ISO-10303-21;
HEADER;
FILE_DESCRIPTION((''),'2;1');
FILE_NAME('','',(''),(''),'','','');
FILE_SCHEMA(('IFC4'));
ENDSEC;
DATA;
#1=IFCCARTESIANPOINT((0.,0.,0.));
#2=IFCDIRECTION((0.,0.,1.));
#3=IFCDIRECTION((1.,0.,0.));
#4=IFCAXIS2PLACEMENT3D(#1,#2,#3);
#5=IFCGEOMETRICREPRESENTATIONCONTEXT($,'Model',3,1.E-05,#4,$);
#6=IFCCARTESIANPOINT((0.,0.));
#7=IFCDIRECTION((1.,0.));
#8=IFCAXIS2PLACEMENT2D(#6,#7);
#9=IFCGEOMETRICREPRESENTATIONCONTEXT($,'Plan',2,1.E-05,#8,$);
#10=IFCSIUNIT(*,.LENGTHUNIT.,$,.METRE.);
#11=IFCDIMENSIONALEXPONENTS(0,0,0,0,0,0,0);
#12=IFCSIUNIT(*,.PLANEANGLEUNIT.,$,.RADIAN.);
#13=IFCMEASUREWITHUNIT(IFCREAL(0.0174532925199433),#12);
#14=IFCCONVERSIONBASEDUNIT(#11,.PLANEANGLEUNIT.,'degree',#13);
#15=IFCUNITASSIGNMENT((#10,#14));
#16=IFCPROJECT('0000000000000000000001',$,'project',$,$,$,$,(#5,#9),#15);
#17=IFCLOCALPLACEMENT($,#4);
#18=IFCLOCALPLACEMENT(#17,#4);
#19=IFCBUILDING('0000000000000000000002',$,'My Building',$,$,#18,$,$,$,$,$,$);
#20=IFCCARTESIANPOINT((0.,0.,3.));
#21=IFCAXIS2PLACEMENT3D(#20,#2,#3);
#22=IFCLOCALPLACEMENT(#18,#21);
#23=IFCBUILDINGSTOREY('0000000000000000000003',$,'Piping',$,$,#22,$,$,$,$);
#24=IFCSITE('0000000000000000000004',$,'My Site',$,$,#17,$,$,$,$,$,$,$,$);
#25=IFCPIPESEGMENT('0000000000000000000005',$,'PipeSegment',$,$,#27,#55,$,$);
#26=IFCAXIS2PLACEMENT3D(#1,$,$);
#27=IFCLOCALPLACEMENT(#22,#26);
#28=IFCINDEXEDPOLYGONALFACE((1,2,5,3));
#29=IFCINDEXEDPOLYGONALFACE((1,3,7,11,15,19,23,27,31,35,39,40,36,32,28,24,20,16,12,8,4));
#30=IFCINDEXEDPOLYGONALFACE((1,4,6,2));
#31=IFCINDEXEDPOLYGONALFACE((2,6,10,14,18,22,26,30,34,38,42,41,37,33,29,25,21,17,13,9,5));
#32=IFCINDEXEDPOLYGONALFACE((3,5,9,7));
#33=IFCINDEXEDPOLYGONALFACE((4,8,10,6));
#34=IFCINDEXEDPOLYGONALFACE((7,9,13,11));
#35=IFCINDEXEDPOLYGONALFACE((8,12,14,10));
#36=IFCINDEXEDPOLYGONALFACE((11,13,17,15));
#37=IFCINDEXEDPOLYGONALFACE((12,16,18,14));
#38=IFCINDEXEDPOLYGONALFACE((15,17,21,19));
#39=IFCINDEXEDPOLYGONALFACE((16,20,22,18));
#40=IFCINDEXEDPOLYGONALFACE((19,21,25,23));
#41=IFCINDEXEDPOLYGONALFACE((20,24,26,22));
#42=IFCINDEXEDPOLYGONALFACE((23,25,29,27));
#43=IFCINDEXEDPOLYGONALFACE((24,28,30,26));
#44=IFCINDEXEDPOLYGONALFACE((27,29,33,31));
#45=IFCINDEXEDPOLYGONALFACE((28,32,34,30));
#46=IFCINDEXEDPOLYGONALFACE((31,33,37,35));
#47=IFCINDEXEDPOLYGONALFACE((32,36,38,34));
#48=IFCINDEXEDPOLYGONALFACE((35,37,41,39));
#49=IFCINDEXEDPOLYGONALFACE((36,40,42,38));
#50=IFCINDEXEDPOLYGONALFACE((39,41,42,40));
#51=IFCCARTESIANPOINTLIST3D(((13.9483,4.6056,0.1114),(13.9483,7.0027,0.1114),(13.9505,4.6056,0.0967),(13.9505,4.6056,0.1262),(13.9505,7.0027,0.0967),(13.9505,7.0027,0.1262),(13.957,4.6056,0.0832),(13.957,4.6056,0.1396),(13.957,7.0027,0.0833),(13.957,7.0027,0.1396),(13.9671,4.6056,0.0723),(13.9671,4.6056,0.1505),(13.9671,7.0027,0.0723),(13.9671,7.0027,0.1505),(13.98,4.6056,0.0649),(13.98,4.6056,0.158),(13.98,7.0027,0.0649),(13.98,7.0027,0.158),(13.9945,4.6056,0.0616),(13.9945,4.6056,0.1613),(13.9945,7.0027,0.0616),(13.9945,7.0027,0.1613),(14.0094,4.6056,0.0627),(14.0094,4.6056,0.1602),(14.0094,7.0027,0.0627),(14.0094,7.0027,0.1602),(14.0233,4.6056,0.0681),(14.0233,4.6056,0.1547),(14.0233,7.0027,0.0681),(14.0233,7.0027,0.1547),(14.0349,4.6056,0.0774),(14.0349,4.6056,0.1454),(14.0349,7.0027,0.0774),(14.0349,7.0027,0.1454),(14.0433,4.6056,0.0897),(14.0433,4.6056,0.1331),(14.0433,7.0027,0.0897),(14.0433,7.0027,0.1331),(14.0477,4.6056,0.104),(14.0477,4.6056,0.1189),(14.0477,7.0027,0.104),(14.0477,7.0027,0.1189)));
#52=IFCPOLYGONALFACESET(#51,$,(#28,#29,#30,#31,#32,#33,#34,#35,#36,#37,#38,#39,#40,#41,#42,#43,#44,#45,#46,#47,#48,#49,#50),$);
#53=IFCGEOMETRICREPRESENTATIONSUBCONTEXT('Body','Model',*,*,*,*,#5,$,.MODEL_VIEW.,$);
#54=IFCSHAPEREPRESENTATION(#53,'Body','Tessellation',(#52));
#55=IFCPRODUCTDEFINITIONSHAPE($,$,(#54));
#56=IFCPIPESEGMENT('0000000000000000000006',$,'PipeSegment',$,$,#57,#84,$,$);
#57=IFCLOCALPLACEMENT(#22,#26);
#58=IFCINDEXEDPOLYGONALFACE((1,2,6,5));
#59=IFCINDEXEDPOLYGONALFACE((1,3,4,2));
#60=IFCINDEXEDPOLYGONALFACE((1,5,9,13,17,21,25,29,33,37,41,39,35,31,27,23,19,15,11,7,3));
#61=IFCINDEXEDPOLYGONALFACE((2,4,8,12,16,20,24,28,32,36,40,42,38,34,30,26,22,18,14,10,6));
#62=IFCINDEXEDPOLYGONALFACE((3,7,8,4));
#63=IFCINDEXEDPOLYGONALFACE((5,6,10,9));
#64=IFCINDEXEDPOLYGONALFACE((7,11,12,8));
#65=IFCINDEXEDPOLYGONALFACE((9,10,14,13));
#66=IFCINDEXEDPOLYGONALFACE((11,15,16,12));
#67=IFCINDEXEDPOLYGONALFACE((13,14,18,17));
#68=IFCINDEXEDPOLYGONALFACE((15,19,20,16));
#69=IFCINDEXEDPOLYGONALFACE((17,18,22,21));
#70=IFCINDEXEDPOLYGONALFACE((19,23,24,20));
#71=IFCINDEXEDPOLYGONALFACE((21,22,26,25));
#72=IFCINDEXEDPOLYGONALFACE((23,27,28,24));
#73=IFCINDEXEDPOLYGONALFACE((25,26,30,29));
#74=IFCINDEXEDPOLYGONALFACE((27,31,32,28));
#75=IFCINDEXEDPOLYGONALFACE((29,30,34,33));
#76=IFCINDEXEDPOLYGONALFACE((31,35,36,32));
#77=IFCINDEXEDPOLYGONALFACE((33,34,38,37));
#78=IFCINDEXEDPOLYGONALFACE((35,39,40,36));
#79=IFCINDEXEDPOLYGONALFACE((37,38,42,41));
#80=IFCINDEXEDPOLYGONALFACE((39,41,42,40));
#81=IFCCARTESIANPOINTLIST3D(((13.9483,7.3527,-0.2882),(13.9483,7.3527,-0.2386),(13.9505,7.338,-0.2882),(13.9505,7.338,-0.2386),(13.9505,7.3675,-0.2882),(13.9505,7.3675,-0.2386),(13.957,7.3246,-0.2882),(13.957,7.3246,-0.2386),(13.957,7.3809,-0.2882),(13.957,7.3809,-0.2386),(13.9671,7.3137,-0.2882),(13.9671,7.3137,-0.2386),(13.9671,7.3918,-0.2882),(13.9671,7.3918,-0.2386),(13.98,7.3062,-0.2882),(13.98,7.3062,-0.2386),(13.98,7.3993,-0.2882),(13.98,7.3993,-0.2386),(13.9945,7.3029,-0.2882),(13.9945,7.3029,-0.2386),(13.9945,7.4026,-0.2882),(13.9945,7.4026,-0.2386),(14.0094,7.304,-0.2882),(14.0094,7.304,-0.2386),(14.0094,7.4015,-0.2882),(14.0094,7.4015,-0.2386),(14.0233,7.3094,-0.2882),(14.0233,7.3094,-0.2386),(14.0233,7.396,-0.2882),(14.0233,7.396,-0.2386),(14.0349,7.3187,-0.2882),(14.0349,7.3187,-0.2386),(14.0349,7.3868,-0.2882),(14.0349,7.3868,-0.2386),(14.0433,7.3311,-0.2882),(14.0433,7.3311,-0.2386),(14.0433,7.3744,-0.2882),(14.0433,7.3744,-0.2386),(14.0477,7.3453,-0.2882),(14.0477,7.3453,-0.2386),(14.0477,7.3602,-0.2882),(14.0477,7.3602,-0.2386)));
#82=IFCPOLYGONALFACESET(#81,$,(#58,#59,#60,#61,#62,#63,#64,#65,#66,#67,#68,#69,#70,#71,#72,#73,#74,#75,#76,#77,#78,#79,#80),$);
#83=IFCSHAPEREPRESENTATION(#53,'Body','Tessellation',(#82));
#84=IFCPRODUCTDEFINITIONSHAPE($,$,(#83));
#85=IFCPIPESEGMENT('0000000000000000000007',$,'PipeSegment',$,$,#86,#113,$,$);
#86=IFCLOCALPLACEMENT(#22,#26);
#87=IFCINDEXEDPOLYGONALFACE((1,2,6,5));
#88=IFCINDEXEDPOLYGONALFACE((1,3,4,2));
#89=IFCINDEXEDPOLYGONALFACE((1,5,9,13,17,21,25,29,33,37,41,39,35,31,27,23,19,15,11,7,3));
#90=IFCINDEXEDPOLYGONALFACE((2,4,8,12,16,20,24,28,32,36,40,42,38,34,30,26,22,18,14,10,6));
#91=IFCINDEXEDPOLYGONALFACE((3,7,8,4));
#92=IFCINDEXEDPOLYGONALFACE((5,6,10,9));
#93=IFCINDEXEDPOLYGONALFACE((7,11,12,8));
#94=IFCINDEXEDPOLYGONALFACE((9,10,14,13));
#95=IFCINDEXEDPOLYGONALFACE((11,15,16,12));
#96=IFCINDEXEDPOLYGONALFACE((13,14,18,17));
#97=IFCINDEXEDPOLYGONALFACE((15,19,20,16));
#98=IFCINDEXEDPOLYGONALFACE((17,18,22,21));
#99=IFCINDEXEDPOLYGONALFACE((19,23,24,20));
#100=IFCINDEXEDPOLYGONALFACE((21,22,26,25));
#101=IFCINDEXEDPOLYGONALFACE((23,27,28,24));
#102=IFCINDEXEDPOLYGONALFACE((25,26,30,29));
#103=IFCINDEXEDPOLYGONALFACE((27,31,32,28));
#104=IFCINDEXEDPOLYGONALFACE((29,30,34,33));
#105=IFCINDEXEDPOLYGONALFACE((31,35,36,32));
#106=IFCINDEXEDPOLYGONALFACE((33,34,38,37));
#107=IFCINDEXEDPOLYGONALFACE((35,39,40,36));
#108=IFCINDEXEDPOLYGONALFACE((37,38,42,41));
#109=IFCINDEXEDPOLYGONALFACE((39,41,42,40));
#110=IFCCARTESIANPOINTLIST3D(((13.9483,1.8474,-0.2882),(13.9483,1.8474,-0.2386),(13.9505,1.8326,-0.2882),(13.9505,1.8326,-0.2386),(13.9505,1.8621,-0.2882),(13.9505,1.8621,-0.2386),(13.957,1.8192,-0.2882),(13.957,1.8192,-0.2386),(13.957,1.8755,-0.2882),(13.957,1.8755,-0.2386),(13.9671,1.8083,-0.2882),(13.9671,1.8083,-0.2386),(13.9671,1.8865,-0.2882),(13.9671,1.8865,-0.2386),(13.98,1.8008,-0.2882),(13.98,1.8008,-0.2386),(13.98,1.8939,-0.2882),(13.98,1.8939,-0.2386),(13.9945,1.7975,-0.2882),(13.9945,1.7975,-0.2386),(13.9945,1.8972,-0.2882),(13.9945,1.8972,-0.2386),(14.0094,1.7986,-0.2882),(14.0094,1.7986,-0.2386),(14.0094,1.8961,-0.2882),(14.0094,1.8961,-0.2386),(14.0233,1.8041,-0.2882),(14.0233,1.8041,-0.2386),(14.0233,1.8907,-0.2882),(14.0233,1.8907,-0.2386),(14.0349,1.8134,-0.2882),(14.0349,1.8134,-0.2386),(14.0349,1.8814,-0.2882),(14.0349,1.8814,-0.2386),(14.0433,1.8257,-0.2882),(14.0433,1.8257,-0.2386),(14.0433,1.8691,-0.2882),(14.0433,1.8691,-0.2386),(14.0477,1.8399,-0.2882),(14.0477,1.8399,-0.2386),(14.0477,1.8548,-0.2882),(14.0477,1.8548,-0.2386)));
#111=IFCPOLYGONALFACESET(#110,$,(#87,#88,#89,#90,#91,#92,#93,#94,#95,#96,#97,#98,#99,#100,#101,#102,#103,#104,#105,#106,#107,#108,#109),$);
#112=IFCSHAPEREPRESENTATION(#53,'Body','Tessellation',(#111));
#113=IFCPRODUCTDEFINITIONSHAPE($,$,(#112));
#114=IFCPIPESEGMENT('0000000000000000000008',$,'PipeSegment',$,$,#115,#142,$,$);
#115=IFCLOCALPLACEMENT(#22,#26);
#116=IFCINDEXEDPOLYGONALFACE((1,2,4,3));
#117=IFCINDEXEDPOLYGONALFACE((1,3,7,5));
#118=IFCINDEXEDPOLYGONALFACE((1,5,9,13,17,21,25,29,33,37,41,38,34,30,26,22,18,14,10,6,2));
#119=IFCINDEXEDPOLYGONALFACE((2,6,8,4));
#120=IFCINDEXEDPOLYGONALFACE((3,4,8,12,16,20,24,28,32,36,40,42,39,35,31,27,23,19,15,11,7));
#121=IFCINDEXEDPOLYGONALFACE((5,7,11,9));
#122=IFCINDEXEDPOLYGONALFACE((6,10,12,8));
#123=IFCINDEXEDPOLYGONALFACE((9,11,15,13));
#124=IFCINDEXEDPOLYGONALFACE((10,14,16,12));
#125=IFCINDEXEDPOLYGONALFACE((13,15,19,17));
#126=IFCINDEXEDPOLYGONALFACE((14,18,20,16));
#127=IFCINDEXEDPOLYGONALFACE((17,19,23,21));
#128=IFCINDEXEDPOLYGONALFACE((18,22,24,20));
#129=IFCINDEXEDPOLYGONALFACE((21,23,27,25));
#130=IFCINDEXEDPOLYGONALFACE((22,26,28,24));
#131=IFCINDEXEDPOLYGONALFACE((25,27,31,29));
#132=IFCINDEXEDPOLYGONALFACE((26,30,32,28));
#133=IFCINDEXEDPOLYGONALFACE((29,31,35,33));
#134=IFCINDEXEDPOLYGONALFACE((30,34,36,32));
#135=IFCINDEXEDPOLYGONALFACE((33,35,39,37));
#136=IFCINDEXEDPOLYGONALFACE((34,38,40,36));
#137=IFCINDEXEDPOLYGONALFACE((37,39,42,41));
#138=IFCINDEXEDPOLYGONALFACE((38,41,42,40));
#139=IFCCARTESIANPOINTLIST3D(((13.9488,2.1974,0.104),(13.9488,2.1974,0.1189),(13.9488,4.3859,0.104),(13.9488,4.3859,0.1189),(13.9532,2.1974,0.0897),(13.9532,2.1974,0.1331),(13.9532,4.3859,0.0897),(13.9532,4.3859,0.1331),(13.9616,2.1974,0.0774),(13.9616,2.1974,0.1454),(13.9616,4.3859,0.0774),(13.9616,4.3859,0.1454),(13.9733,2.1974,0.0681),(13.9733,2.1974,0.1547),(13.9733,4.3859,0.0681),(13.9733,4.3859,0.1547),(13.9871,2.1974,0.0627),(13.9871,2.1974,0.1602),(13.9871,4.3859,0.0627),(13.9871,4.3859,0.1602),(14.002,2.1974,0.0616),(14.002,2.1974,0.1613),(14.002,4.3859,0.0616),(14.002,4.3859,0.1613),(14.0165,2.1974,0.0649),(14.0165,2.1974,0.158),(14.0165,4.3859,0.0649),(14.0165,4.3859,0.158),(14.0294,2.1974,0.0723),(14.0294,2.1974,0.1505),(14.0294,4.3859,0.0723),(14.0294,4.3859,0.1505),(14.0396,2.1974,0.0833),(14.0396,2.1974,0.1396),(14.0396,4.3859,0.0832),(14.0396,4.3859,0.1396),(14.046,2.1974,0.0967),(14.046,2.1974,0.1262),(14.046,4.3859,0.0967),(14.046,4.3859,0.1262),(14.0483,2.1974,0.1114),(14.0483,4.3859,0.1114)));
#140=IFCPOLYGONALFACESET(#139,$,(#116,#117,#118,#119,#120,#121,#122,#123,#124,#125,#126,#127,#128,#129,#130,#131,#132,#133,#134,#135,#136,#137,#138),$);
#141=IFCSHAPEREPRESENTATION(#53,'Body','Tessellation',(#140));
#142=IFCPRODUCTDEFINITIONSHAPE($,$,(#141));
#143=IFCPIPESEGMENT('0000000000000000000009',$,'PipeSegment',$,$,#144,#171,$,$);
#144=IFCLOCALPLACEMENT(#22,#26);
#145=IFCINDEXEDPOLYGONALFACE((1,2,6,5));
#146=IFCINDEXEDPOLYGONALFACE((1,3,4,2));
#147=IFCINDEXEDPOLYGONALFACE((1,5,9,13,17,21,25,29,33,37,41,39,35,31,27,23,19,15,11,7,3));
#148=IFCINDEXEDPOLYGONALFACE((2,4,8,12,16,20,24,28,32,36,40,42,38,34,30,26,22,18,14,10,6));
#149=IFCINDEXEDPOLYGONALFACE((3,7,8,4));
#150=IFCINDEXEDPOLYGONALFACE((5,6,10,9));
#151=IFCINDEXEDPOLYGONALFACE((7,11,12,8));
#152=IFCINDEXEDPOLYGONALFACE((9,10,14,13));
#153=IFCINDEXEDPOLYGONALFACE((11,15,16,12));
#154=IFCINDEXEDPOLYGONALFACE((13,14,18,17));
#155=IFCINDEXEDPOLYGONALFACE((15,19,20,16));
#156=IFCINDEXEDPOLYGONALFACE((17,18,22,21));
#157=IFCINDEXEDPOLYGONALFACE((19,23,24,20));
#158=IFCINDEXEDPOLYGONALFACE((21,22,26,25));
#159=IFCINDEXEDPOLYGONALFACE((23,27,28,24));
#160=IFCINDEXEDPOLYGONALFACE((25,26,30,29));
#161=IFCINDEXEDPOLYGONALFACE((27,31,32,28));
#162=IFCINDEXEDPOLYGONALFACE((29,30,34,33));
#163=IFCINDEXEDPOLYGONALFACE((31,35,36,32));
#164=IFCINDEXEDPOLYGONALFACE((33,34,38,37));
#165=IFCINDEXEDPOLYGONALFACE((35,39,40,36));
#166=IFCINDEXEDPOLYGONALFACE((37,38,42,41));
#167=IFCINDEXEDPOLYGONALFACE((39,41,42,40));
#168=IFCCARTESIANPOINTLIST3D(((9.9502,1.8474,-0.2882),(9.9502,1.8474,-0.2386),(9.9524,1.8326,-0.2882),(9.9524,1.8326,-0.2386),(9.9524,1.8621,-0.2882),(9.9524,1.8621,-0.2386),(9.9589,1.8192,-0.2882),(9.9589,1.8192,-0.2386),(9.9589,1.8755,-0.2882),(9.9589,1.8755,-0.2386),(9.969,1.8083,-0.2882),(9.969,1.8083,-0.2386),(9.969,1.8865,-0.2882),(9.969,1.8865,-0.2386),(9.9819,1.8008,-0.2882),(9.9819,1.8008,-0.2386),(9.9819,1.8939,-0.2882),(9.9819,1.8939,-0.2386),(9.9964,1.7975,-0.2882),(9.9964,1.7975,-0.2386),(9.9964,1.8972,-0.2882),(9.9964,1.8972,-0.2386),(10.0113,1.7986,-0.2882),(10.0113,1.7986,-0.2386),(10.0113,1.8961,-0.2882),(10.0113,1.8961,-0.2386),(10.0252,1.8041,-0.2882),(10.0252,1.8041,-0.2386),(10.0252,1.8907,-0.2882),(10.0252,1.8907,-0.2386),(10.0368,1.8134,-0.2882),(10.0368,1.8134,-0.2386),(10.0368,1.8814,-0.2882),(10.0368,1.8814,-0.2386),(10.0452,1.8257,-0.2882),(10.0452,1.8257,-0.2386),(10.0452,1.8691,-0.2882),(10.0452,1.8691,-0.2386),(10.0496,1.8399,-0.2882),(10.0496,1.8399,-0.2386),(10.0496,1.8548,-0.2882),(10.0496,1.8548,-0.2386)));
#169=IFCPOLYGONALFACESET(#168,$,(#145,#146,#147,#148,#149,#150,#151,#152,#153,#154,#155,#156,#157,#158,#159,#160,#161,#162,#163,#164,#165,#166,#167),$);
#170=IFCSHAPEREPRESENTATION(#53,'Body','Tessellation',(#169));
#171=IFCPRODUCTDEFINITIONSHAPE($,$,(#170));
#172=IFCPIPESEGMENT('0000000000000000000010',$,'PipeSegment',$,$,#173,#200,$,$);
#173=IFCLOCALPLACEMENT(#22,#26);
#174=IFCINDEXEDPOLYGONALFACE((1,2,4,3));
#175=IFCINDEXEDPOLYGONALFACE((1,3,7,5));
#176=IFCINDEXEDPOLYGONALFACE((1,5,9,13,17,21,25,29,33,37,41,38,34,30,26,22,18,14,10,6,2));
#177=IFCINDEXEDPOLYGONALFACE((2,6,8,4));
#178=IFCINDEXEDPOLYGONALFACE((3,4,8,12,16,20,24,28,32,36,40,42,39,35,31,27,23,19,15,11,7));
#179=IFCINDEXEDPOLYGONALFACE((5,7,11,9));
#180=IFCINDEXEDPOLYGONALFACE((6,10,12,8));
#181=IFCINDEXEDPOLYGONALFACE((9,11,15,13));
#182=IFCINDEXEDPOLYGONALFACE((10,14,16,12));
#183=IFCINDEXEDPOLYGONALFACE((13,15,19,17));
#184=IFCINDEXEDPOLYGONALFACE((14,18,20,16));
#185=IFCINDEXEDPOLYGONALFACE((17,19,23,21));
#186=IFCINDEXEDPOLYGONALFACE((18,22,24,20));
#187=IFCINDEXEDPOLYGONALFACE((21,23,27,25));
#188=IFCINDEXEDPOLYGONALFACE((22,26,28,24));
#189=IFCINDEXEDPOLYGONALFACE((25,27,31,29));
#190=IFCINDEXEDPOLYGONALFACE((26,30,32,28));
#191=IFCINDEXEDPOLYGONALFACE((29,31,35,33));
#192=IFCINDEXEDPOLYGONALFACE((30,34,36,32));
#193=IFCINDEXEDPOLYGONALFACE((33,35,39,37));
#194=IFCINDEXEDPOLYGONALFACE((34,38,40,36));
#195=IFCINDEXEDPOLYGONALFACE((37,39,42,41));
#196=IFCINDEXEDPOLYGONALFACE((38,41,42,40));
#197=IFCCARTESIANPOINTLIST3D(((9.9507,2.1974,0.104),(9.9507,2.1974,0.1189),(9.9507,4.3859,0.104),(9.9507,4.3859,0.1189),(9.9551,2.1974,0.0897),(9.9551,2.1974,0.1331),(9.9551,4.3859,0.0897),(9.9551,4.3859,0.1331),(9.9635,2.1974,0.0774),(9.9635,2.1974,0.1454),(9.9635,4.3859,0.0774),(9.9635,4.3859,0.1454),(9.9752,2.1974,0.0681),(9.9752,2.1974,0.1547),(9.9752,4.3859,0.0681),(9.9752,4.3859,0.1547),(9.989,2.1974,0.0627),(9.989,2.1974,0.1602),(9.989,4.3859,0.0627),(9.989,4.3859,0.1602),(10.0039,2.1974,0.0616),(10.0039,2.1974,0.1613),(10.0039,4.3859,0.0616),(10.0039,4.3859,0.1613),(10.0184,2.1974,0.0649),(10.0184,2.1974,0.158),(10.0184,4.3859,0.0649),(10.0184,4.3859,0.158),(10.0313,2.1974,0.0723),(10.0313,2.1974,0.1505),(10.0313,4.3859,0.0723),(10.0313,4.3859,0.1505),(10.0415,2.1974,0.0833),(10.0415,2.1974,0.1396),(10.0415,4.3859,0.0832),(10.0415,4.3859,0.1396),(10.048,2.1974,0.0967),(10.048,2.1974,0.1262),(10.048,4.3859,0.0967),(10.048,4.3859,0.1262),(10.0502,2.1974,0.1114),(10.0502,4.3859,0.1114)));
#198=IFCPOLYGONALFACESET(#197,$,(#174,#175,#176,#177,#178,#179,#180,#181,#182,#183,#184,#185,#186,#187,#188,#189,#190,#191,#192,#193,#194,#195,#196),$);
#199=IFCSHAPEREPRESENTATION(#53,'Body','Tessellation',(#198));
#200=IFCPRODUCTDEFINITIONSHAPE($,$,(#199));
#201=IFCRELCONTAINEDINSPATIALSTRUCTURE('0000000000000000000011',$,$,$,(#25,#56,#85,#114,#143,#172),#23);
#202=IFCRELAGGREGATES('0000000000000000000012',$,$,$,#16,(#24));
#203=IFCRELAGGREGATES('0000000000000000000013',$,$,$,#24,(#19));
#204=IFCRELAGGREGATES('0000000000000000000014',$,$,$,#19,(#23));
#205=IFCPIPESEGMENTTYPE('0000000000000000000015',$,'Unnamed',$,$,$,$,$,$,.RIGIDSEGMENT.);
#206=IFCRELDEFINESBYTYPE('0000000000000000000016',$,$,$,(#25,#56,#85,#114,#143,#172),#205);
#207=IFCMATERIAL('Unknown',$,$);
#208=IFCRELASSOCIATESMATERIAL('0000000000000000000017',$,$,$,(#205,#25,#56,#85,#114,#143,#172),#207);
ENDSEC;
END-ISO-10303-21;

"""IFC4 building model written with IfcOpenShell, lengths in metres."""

from ifc_helpers import new_model, entity, si_unit, converted_unit, frame, origin_with_axes, origin_2d_with_axis, place, context, subcontext, project, spatial, circle, extrude, material, material_profile, profile_set, profile_usage, type_object, element, save


model = new_model("IFC4")

# Units and contexts
model_context = context("Model", 3, precision=1e-05, world=origin_with_axes())
plan_context = context("Plan", 2, precision=1e-05, world=origin_2d_with_axis())
body_context = subcontext(model_context, "Body", "Model", "MODEL_VIEW")
ifc_project = project(units=[si_unit("LENGTHUNIT", "METRE"), converted_unit("PLANEANGLEUNIT", "degree", entity("IfcReal", 0.0174532925199433), si_unit("PLANEANGLEUNIT", "RADIAN"), dimensions=[0, 0, 0, 0, 0, 0, 0])], contexts=[model_context, plan_context])

# Site, building, storey
site_placement = place(None, origin_with_axes())
site = spatial("IfcSite", under=ifc_project, at=site_placement, Name="My Site")
building_placement = place(site_placement, origin_with_axes())
building = spatial("IfcBuilding", under=site, at=building_placement, Name="My Building")
storey_placement = place(building_placement, frame((0.0, 0.0, 3.0), z_axis=(0.0, 0.0, 1.0), x_axis=(1.0, 0.0, 0.0)))
storey = spatial("IfcBuildingStorey", under=building, at=storey_placement, Name="Piping")

# Pipe segments
ifc_material = material(Name="Unknown")
ifc_material_profile_1 = material_profile(ifc_material, circle(Radius=0.05))
ifc_profile_set_1 = profile_set([ifc_material_profile_1])
ifc_profile_usage_1 = profile_usage(ifc_profile_set_1, cardinal=16)
pipe_segment_type = type_object("IfcPipeSegmentType", Name="Unnamed", PredefinedType="RIGIDSEGMENT", material=ifc_profile_set_1)
pipe_segment_1_placement = place(storey_placement, frame((13.9983, 4.6056, 0.1114), z_axis=(0.0, 1.0, 0.0), x_axis=(-1.0, 0.0, 0.0)))
element("IfcPipeSegment", 1, at=pipe_segment_1_placement, inside=storey, type_object=pipe_segment_type, material=ifc_profile_usage_1, Name="PipeSegment", context=body_context, shape_type="SweptSolid", body=[
    extrude(circle(Radius=0.05), origin_with_axes(), (0.0, 0.0, 1.0), 2.3972),
])
ifc_profile_usage_2 = profile_usage(ifc_profile_set_1, cardinal=16)
pipe_segment_2_placement = place(storey_placement, frame((13.9983, 7.3527, -0.2386), z_axis=(0.0, 0.0, -1.0), x_axis=(-1.0, 0.0, 0.0)))
element("IfcPipeSegment", 2, at=pipe_segment_2_placement, inside=storey, type_object=pipe_segment_type, material=ifc_profile_usage_2, Name="PipeSegment", context=body_context, shape_type="SweptSolid", body=[
    extrude(circle(Radius=0.05), origin_with_axes(), (0.0, 0.0, 1.0), 0.0496),
])
ifc_profile_usage_3 = profile_usage(ifc_profile_set_1, cardinal=16)
pipe_segment_3_placement = place(storey_placement, frame((13.9983, 1.8474, -0.2386), z_axis=(0.0, 0.0, -1.0), x_axis=(-1.0, 0.0, 0.0)))
element("IfcPipeSegment", 3, at=pipe_segment_3_placement, inside=storey, type_object=pipe_segment_type, material=ifc_profile_usage_3, Name="PipeSegment", context=body_context, shape_type="SweptSolid", body=[
    extrude(circle(Radius=0.05), origin_with_axes(), (0.0, 0.0, 1.0), 0.0496),
])
ifc_profile_usage_4 = profile_usage(ifc_profile_set_1, cardinal=16)
pipe_segment_4_placement = place(storey_placement, frame((13.9983, 4.3859, 0.1114), z_axis=(0.0, -1.0, 0.0), x_axis=(1.0, 0.0, 0.0)))
element("IfcPipeSegment", 4, at=pipe_segment_4_placement, inside=storey, type_object=pipe_segment_type, material=ifc_profile_usage_4, Name="PipeSegment", context=body_context, shape_type="SweptSolid", body=[
    extrude(circle(Radius=0.05), origin_with_axes(), (0.0, 0.0, 1.0), 2.1885),
])
ifc_profile_usage_5 = profile_usage(ifc_profile_set_1, cardinal=16)
pipe_segment_5_placement = place(storey_placement, frame((10.0002, 1.8474, -0.2386), z_axis=(0.0, 0.0, -1.0), x_axis=(-1.0, 0.0, 0.0)))
element("IfcPipeSegment", 5, at=pipe_segment_5_placement, inside=storey, type_object=pipe_segment_type, material=ifc_profile_usage_5, Name="PipeSegment", context=body_context, shape_type="SweptSolid", body=[
    extrude(circle(Radius=0.05), origin_with_axes(), (0.0, 0.0, 1.0), 0.0496),
])
ifc_profile_usage_6 = profile_usage(ifc_profile_set_1, cardinal=16)
pipe_segment_6_placement = place(storey_placement, frame((10.0002, 4.3859, 0.1114), z_axis=(0.0, -1.0, 0.0), x_axis=(1.0, 0.0, 0.0)))
element("IfcPipeSegment", 6, at=pipe_segment_6_placement, inside=storey, type_object=pipe_segment_type, material=ifc_profile_usage_6, Name="PipeSegment", context=body_context, shape_type="SweptSolid", body=[
    extrude(circle(Radius=0.05), origin_with_axes(), (0.0, 0.0, 1.0), 2.1885),
])

save(model, "model.ifc")
